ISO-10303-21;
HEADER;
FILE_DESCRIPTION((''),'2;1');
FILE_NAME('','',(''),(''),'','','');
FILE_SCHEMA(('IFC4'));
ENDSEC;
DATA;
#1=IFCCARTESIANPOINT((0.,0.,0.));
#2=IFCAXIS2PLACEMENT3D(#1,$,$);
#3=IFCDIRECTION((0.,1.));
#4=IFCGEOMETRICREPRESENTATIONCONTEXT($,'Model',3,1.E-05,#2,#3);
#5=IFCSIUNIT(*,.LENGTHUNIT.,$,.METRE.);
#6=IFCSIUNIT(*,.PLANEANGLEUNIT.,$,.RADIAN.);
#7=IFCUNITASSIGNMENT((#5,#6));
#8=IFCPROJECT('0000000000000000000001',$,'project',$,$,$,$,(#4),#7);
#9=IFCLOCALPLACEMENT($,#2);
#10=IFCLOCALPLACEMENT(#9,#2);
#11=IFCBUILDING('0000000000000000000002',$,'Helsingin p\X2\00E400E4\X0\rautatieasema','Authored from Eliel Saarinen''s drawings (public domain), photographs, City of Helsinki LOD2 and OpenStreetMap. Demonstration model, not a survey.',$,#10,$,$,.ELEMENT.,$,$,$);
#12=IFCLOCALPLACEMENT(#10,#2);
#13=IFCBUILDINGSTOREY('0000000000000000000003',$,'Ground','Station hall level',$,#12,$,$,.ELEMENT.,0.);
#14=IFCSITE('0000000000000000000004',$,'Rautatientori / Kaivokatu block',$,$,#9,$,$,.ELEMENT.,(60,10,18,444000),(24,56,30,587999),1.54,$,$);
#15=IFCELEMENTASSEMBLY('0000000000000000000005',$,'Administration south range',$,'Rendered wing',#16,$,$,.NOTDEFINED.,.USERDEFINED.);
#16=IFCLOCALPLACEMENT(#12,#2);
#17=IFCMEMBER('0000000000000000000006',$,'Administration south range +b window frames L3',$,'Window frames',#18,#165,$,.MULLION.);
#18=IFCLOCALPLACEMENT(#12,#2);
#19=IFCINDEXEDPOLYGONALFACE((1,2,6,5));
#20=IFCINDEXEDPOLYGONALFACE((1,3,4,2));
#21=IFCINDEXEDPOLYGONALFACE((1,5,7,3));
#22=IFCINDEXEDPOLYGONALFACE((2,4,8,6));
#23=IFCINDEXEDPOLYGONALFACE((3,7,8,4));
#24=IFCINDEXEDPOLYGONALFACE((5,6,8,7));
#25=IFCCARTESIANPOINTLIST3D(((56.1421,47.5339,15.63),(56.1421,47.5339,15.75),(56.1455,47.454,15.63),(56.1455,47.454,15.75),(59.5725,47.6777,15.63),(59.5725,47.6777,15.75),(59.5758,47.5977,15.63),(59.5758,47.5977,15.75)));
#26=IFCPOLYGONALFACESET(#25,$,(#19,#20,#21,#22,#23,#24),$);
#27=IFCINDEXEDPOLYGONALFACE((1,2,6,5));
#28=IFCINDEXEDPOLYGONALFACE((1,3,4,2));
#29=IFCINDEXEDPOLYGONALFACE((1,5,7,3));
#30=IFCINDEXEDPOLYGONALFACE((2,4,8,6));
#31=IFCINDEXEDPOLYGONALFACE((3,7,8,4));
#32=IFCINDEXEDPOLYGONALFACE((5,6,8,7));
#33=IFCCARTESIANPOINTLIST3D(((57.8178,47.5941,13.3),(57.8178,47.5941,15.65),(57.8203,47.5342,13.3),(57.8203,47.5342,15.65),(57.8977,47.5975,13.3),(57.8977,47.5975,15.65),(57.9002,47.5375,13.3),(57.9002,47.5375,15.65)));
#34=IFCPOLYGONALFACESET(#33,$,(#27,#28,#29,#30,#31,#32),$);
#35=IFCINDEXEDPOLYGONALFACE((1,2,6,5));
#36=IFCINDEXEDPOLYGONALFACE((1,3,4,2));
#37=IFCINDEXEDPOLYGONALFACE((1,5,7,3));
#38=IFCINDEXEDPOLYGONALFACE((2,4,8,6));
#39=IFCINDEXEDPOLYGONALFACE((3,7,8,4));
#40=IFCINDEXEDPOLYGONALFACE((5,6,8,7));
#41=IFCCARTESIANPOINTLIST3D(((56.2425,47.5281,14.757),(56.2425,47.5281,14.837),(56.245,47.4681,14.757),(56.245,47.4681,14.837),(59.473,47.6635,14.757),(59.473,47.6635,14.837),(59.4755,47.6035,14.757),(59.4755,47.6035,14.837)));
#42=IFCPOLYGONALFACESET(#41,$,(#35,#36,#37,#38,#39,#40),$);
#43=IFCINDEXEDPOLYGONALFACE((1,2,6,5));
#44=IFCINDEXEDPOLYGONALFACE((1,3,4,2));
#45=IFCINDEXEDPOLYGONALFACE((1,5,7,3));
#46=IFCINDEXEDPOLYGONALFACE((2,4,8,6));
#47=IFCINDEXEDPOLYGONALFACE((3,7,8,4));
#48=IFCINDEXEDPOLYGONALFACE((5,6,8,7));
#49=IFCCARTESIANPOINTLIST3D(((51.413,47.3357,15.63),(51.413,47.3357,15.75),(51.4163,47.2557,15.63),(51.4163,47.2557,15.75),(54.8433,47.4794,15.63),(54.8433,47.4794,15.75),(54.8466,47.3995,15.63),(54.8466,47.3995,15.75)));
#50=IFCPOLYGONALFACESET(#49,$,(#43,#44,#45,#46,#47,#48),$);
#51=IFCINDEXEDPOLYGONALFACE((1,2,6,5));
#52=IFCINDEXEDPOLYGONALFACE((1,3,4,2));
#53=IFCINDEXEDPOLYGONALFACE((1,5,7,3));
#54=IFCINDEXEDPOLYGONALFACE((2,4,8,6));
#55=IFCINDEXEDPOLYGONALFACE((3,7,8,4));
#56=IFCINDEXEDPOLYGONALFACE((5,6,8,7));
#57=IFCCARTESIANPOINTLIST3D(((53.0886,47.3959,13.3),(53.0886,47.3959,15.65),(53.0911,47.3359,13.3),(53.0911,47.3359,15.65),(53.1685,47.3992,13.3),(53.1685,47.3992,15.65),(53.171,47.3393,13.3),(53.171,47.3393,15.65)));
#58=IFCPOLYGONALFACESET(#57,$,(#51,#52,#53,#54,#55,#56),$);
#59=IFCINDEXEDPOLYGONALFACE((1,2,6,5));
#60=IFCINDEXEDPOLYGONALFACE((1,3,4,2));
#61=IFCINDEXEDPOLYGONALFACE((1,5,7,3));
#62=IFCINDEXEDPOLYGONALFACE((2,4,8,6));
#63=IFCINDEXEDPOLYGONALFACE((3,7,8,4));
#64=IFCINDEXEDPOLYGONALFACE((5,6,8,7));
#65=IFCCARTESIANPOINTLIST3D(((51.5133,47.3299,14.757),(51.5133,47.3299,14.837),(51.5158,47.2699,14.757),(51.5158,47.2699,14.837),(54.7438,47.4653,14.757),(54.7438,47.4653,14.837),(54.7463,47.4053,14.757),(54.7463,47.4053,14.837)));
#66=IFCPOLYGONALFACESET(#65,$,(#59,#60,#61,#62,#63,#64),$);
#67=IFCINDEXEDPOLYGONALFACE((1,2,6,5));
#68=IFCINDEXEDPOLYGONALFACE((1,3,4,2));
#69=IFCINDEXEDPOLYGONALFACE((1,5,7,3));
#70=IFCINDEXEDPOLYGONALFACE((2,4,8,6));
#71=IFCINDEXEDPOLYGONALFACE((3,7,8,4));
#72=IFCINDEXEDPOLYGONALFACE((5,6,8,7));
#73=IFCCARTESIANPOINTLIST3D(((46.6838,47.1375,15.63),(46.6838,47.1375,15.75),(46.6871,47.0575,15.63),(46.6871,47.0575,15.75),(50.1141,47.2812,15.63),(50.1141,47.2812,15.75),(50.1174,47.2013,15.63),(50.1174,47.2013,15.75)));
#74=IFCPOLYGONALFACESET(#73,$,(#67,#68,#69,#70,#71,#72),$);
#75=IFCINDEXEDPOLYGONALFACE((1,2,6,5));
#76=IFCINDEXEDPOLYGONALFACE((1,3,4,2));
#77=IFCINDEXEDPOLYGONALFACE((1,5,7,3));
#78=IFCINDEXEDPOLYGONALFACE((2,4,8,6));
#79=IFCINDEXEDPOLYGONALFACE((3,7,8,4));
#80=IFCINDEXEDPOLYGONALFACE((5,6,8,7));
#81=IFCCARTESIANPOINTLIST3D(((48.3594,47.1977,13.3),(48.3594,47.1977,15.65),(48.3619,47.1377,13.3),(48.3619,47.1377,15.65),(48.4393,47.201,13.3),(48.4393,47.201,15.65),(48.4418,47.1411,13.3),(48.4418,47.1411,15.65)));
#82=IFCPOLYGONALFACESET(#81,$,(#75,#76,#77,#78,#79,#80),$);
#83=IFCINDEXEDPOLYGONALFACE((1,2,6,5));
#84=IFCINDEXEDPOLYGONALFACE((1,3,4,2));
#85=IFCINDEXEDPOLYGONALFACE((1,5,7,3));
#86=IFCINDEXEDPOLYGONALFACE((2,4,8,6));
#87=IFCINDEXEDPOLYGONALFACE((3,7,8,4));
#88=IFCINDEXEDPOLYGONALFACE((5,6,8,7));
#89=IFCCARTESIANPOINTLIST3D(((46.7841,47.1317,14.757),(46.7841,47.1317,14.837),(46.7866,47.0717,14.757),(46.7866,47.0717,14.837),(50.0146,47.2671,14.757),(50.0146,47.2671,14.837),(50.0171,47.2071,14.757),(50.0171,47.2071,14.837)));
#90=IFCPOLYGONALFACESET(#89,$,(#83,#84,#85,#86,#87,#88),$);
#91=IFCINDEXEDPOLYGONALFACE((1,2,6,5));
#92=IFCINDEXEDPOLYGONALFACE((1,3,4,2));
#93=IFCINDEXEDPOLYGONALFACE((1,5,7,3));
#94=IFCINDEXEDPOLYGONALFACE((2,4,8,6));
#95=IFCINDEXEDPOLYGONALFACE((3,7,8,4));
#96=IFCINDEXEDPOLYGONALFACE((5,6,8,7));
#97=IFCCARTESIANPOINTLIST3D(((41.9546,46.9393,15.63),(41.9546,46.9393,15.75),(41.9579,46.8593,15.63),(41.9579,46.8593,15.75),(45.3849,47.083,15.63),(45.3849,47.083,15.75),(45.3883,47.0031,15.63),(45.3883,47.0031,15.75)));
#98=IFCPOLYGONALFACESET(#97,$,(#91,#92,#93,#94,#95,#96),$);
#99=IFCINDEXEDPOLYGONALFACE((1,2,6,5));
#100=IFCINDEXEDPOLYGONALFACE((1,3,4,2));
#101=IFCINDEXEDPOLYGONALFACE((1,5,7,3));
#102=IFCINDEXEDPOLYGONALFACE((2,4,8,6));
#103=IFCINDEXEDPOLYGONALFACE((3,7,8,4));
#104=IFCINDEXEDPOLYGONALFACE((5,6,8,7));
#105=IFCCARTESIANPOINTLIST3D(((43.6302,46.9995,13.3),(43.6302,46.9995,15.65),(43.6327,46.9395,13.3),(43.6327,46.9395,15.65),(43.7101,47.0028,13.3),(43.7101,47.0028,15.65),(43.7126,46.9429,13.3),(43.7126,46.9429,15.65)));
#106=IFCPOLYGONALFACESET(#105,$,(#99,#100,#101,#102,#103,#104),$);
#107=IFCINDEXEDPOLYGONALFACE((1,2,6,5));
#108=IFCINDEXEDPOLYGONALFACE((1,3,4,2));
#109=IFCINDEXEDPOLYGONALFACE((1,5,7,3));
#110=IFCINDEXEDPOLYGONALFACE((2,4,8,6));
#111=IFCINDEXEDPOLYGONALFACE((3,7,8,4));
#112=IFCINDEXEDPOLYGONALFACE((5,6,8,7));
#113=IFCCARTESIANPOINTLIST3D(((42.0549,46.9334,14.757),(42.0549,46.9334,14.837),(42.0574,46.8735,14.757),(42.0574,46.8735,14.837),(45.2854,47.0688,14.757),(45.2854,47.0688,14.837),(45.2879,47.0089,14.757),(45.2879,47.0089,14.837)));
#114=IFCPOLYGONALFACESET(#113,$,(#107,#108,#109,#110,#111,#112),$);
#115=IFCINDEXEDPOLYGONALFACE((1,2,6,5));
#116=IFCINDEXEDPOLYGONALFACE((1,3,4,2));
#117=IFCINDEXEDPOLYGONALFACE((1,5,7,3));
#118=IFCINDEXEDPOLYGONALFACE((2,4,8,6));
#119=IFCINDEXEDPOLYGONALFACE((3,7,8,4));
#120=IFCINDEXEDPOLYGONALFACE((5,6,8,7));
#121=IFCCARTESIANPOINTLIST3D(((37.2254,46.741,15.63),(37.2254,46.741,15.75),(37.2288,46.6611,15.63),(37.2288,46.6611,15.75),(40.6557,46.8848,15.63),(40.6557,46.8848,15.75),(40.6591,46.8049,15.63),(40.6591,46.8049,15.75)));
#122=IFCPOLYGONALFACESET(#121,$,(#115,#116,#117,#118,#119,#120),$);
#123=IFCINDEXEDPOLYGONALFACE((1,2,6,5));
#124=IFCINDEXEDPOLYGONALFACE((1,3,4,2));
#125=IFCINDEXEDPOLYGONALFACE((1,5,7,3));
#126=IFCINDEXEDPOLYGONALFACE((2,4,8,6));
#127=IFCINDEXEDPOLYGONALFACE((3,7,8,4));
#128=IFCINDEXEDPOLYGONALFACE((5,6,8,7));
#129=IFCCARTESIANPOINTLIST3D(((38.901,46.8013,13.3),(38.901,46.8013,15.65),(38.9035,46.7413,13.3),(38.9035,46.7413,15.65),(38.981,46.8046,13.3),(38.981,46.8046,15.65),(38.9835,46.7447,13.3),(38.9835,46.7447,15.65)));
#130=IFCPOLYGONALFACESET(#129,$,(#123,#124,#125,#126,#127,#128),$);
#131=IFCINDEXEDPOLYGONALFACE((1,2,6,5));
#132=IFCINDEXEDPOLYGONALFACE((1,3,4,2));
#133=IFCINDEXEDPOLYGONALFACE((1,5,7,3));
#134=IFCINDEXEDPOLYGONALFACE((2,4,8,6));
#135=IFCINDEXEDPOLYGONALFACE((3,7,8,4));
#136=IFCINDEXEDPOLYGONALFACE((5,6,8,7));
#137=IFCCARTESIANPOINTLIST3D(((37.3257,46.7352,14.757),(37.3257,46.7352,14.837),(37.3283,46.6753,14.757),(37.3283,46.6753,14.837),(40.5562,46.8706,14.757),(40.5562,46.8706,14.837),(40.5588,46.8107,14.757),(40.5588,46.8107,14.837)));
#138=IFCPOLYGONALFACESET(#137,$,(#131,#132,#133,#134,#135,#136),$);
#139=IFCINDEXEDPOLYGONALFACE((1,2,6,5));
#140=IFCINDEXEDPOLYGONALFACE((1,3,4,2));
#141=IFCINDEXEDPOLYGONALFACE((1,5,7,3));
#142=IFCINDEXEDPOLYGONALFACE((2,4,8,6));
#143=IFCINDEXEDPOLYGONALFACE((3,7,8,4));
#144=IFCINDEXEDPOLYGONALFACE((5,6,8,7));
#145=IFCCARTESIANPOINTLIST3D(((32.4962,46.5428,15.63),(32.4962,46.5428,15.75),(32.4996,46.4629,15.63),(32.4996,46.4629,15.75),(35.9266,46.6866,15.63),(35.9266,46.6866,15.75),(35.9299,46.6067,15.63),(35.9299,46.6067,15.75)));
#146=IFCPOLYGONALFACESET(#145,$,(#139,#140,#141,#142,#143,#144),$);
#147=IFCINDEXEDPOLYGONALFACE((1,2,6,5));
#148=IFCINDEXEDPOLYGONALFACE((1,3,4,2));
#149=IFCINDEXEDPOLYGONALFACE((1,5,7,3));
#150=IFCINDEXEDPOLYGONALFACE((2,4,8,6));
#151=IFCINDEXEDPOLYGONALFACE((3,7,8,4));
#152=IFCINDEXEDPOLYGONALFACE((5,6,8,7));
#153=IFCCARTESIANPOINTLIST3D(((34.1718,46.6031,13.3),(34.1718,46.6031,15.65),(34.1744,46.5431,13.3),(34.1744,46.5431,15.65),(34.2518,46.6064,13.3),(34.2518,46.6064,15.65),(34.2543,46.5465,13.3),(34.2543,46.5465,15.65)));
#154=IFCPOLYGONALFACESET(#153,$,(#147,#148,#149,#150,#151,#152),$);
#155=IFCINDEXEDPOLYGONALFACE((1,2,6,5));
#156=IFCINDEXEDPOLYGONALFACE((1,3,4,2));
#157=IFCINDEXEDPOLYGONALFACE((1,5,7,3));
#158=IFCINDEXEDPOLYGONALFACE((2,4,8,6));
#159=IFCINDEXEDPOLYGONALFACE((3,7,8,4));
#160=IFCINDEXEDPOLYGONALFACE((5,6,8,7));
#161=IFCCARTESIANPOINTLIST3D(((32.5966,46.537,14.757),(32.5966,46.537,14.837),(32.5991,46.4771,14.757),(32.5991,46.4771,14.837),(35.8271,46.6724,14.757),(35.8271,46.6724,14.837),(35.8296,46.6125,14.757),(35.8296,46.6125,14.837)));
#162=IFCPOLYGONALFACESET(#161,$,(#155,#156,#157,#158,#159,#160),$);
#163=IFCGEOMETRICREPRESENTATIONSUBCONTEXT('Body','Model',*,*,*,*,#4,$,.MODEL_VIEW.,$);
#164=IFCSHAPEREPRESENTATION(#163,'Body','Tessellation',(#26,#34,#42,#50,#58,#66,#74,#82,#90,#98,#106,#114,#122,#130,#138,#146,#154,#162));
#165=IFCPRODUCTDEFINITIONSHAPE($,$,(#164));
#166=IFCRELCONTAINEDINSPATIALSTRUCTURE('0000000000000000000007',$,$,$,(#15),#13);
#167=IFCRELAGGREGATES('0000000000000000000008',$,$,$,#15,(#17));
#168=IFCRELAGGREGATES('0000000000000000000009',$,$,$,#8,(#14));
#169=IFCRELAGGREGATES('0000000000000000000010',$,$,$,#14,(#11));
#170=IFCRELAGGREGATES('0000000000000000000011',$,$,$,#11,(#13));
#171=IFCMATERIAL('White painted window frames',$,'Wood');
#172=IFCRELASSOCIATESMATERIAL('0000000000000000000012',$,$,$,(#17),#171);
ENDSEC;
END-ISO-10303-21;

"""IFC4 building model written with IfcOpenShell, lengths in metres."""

from ifc_helpers import new_model, si_unit, direction, frame, frame_2d, origin, place, context, subcontext, project, spatial, rectangle, extrude, material, element, aggregate, save


model = new_model("IFC4")

# Units and contexts
model_context = context("Model", 3, precision=1e-05, world=origin(), true_north=direction((0.0, 1.0)))
body_context = subcontext(model_context, "Body", "Model", "MODEL_VIEW")
ifc_project = project(units=[si_unit("LENGTHUNIT", "METRE"), si_unit("PLANEANGLEUNIT", "RADIAN")], contexts=[model_context])

# Site, building, storey
site_placement = place(None, origin())
site = spatial("IfcSite", under=ifc_project, at=site_placement, Name="Rautatientori / Kaivokatu block", CompositionType="ELEMENT", RefLatitude=(60, 10, 18, 444000), RefLongitude=(24, 56, 30, 587999), RefElevation=1.54)
building_placement = place(site_placement, origin())
building = spatial("IfcBuilding", under=site, at=building_placement, Name="Helsingin päärautatieasema", Description="Authored from Eliel Saarinen's drawings (public domain), photographs, City of Helsinki LOD2 and OpenStreetMap. Demonstration model, not a survey.", CompositionType="ELEMENT")
storey_placement = place(building_placement, origin())
storey = spatial("IfcBuildingStorey", under=building, at=storey_placement, Name="Ground", Description="Station hall level", CompositionType="ELEMENT", Elevation=0.0)

# Element assembly, member
assembly_1_placement = place(building_placement, origin())
assembly_1 = element("IfcElementAssembly", 1, at=assembly_1_placement, inside=storey, Name="Administration south range", ObjectType="Rendered wing", AssemblyPlace="NOTDEFINED", PredefinedType="USERDEFINED")
ifc_material_1 = material(Name="White painted window frames", Category="Wood")
member_1_placement = place(building_placement, origin())
member_1 = element("IfcMember", 2, at=member_1_placement, material=ifc_material_1, Name="Administration south range +b window frames L3", ObjectType="Window frames", PredefinedType="MULLION", context=body_context, shape_type="SweptSolid", body=[
    extrude(rectangle(XDim=3.4333, YDim=0.08, at=frame_2d((0.0, 0.0), x_axis=(-0.999123, -0.041876))), frame((57.859, 47.5658, 15.63)), (0.0, 0.0, 1.0), 0.12),
    extrude(rectangle(XDim=0.08, YDim=0.06, at=frame_2d((0.0, 0.0), x_axis=(-0.999123, -0.041876))), frame((57.859, 47.5658, 13.3)), (0.0, 0.0, 1.0), 2.35),
    extrude(rectangle(XDim=3.2333, YDim=0.06, at=frame_2d((0.0, 0.0), x_axis=(-0.999123, -0.041876))), frame((57.859, 47.5658, 14.757)), (0.0, 0.0, 1.0), 0.08),
    extrude(rectangle(XDim=3.4333, YDim=0.08, at=frame_2d((0.0, 0.0), x_axis=(-0.999123, -0.041876))), frame((53.1298, 47.3676, 15.63)), (0.0, 0.0, 1.0), 0.12),
    extrude(rectangle(XDim=0.08, YDim=0.06, at=frame_2d((0.0, 0.0), x_axis=(-0.999123, -0.041876))), frame((53.1298, 47.3676, 13.3)), (0.0, 0.0, 1.0), 2.35),
    extrude(rectangle(XDim=3.2333, YDim=0.06, at=frame_2d((0.0, 0.0), x_axis=(-0.999123, -0.041876))), frame((53.1298, 47.3676, 14.757)), (0.0, 0.0, 1.0), 0.08),
    extrude(rectangle(XDim=3.4333, YDim=0.08, at=frame_2d((0.0, 0.0), x_axis=(-0.999123, -0.041876))), frame((48.4006, 47.1694, 15.63)), (0.0, 0.0, 1.0), 0.12),
    extrude(rectangle(XDim=0.08, YDim=0.06, at=frame_2d((0.0, 0.0), x_axis=(-0.999123, -0.041876))), frame((48.4006, 47.1694, 13.3)), (0.0, 0.0, 1.0), 2.35),
    extrude(rectangle(XDim=3.2333, YDim=0.06, at=frame_2d((0.0, 0.0), x_axis=(-0.999123, -0.041876))), frame((48.4006, 47.1694, 14.757)), (0.0, 0.0, 1.0), 0.08),
    extrude(rectangle(XDim=3.4333, YDim=0.08, at=frame_2d((0.0, 0.0), x_axis=(-0.999123, -0.041876))), frame((43.6714, 46.9712, 15.63)), (0.0, 0.0, 1.0), 0.12),
    extrude(rectangle(XDim=0.08, YDim=0.06, at=frame_2d((0.0, 0.0), x_axis=(-0.999123, -0.041876))), frame((43.6714, 46.9712, 13.3)), (0.0, 0.0, 1.0), 2.35),
    extrude(rectangle(XDim=3.2333, YDim=0.06, at=frame_2d((0.0, 0.0), x_axis=(-0.999123, -0.041876))), frame((43.6714, 46.9712, 14.757)), (0.0, 0.0, 1.0), 0.08),
    extrude(rectangle(XDim=3.4333, YDim=0.08, at=frame_2d((0.0, 0.0), x_axis=(-0.999123, -0.041876))), frame((38.9422, 46.773, 15.63)), (0.0, 0.0, 1.0), 0.12),
    extrude(rectangle(XDim=0.08, YDim=0.06, at=frame_2d((0.0, 0.0), x_axis=(-0.999123, -0.041876))), frame((38.9422, 46.773, 13.3)), (0.0, 0.0, 1.0), 2.35),
    extrude(rectangle(XDim=3.2333, YDim=0.06, at=frame_2d((0.0, 0.0), x_axis=(-0.999123, -0.041876))), frame((38.9422, 46.773, 14.757)), (0.0, 0.0, 1.0), 0.08),
    extrude(rectangle(XDim=3.4333, YDim=0.08, at=frame_2d((0.0, 0.0), x_axis=(-0.999123, -0.041876))), frame((34.2131, 46.5748, 15.63)), (0.0, 0.0, 1.0), 0.12),
    extrude(rectangle(XDim=0.08, YDim=0.06, at=frame_2d((0.0, 0.0), x_axis=(-0.999123, -0.041876))), frame((34.2131, 46.5748, 13.3)), (0.0, 0.0, 1.0), 2.35),
    extrude(rectangle(XDim=3.2333, YDim=0.06, at=frame_2d((0.0, 0.0), x_axis=(-0.999123, -0.041876))), frame((34.2131, 46.5748, 14.757)), (0.0, 0.0, 1.0), 0.08),
])

aggregate(assembly_1, [member_1])

save(model, "model.ifc")
